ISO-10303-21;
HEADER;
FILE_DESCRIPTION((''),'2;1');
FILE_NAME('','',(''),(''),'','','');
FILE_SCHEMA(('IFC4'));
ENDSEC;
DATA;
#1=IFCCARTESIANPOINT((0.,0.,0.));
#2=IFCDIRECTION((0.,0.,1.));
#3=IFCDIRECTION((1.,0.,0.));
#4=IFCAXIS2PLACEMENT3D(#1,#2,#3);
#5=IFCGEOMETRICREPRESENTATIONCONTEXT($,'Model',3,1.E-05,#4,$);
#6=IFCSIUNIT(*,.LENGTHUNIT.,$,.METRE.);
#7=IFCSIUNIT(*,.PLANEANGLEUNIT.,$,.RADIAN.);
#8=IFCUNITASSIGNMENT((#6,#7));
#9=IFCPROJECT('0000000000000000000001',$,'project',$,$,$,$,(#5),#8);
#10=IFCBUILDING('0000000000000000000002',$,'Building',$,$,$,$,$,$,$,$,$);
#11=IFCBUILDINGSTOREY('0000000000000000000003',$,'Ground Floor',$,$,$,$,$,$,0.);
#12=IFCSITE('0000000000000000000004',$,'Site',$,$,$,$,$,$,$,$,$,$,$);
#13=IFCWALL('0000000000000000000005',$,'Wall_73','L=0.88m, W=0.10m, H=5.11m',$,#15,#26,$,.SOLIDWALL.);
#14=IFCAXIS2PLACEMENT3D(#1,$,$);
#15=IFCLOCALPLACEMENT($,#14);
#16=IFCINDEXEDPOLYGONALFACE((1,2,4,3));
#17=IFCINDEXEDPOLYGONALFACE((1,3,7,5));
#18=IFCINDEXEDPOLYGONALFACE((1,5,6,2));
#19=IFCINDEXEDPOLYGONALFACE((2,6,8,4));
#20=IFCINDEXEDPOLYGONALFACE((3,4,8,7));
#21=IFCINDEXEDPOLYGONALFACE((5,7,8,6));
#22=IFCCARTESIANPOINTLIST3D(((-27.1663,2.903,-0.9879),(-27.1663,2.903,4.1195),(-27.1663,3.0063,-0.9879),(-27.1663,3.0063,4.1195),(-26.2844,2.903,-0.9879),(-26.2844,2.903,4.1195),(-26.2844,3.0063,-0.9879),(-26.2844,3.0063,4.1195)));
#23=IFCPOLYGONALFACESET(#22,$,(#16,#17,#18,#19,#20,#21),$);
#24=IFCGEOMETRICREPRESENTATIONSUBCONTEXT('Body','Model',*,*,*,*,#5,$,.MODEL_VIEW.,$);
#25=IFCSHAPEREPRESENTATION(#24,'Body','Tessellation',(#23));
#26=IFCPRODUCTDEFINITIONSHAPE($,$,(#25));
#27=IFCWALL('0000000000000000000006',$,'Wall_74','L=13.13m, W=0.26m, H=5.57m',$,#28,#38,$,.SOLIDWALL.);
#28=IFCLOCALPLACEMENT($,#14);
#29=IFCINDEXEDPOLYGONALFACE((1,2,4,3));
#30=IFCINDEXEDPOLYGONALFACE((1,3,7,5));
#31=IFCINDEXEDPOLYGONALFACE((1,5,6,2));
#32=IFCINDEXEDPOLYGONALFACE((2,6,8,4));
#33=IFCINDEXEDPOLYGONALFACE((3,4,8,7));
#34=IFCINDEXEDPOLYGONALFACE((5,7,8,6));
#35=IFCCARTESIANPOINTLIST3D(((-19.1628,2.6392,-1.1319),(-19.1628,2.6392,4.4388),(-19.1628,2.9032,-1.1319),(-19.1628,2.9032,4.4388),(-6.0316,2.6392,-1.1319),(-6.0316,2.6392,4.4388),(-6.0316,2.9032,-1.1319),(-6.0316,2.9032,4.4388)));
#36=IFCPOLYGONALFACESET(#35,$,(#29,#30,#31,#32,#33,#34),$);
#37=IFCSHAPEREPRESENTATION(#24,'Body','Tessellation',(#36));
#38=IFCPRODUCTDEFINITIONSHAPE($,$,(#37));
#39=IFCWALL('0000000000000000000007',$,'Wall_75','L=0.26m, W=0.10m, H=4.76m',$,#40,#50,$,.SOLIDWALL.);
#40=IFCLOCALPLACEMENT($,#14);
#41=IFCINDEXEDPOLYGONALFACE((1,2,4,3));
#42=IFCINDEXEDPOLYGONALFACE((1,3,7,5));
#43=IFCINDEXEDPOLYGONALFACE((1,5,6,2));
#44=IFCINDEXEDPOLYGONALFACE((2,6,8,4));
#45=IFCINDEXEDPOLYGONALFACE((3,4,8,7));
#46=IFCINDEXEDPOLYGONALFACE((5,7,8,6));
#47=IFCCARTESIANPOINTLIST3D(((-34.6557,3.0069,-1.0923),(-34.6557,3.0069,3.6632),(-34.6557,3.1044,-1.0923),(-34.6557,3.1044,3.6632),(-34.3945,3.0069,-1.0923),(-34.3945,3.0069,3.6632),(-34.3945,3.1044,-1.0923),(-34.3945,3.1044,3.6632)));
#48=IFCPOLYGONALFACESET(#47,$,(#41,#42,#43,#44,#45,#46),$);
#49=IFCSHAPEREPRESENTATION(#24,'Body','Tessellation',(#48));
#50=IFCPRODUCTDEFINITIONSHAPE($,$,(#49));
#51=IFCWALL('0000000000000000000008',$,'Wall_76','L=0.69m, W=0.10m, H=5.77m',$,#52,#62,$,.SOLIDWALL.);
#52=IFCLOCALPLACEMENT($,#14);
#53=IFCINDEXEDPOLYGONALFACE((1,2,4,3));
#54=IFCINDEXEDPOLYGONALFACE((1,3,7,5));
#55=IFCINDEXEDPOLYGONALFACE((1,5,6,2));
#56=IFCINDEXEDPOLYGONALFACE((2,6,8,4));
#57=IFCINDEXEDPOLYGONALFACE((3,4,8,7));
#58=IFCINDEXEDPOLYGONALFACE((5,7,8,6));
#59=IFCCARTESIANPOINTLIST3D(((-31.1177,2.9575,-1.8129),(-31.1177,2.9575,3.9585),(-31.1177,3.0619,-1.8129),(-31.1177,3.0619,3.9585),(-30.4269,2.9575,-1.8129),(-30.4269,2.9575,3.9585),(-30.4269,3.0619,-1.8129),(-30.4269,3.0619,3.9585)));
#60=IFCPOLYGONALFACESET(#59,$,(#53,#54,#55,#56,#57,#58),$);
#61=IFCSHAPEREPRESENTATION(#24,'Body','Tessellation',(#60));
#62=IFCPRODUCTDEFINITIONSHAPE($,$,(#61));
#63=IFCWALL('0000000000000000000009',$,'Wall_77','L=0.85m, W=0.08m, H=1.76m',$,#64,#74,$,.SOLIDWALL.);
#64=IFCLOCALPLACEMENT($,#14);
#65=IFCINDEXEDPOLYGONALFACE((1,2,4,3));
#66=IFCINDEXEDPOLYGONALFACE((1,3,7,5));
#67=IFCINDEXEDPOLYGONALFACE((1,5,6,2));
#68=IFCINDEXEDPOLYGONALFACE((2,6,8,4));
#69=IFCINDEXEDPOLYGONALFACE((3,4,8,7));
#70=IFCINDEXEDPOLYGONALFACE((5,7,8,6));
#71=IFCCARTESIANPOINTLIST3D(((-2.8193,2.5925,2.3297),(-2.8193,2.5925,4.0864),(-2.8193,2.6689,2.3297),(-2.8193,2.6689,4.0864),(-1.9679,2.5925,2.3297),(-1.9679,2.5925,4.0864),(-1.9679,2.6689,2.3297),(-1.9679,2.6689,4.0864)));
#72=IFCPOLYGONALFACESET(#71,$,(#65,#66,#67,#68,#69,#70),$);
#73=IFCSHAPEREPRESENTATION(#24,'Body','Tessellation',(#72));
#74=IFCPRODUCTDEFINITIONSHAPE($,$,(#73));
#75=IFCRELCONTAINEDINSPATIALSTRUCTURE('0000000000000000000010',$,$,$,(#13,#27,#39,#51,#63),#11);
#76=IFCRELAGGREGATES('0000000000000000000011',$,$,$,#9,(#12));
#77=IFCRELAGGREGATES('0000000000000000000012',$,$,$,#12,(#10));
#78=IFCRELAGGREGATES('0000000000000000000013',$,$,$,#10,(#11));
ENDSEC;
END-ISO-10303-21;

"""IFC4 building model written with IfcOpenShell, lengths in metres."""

from ifc_helpers import new_model, si_unit, frame, origin_with_axes, origin_2d, context, subcontext, project, spatial, rectangle, extrude, element, save


model = new_model("IFC4")

# Units and contexts
model_context = context("Model", 3, precision=1e-05, world=origin_with_axes())
body_context = subcontext(model_context, "Body", "Model", "MODEL_VIEW")
ifc_project = project(units=[si_unit("LENGTHUNIT", "METRE"), si_unit("PLANEANGLEUNIT", "RADIAN")], contexts=[model_context])

# Site, building, storey
site = spatial("IfcSite", under=ifc_project, Name="Site")
building = spatial("IfcBuilding", under=site, Name="Building")
storey = spatial("IfcBuildingStorey", under=building, Name="Ground Floor", Elevation=0.0)

# Walls
element("IfcWall", 1, inside=storey, Name="Wall_73", Description="L=0.88m, W=0.10m, H=5.11m", PredefinedType="SOLIDWALL", context=body_context, shape_type="SweptSolid", body=[
    extrude(rectangle(XDim=0.8819, YDim=0.1033, at=origin_2d()), frame((-26.7254, 2.9547, -0.9879), z_axis=(0.0, 0.0, 1.0), x_axis=(1.0, 0.0, 0.0)), (0.0, 0.0, 1.0), 5.1075),
])
element("IfcWall", 2, inside=storey, Name="Wall_74", Description="L=13.13m, W=0.26m, H=5.57m", PredefinedType="SOLIDWALL", context=body_context, shape_type="SweptSolid", body=[
    extrude(rectangle(XDim=13.1312, YDim=0.264, at=origin_2d()), frame((-12.5972, 2.7712, -1.1319), z_axis=(0.0, 0.0, 1.0), x_axis=(1.0, 0.0, 0.0)), (0.0, 0.0, 1.0), 5.5707),
])
element("IfcWall", 3, inside=storey, Name="Wall_75", Description="L=0.26m, W=0.10m, H=4.76m", PredefinedType="SOLIDWALL", context=body_context, shape_type="SweptSolid", body=[
    extrude(rectangle(XDim=0.2612, YDim=0.0975, at=origin_2d()), frame((-34.5251, 3.0556, -1.0923), z_axis=(0.0, 0.0, 1.0), x_axis=(1.0, 0.0, 0.0)), (0.0, 0.0, 1.0), 4.7555),
])
element("IfcWall", 4, inside=storey, Name="Wall_76", Description="L=0.69m, W=0.10m, H=5.77m", PredefinedType="SOLIDWALL", context=body_context, shape_type="SweptSolid", body=[
    extrude(rectangle(XDim=0.6907, YDim=0.1044, at=origin_2d()), frame((-30.7723, 3.0097, -1.8129), z_axis=(0.0, 0.0, 1.0), x_axis=(1.0, 0.0, 0.0)), (0.0, 0.0, 1.0), 5.7715),
])
element("IfcWall", 5, inside=storey, Name="Wall_77", Description="L=0.85m, W=0.08m, H=1.76m", PredefinedType="SOLIDWALL", context=body_context, shape_type="SweptSolid", body=[
    extrude(rectangle(XDim=0.8514, YDim=0.0764, at=origin_2d()), frame((-2.3936, 2.6307, 2.3297), z_axis=(0.0, 0.0, 1.0), x_axis=(1.0, 0.0, 0.0)), (0.0, 0.0, 1.0), 1.7568),
])

save(model, "model.ifc")
